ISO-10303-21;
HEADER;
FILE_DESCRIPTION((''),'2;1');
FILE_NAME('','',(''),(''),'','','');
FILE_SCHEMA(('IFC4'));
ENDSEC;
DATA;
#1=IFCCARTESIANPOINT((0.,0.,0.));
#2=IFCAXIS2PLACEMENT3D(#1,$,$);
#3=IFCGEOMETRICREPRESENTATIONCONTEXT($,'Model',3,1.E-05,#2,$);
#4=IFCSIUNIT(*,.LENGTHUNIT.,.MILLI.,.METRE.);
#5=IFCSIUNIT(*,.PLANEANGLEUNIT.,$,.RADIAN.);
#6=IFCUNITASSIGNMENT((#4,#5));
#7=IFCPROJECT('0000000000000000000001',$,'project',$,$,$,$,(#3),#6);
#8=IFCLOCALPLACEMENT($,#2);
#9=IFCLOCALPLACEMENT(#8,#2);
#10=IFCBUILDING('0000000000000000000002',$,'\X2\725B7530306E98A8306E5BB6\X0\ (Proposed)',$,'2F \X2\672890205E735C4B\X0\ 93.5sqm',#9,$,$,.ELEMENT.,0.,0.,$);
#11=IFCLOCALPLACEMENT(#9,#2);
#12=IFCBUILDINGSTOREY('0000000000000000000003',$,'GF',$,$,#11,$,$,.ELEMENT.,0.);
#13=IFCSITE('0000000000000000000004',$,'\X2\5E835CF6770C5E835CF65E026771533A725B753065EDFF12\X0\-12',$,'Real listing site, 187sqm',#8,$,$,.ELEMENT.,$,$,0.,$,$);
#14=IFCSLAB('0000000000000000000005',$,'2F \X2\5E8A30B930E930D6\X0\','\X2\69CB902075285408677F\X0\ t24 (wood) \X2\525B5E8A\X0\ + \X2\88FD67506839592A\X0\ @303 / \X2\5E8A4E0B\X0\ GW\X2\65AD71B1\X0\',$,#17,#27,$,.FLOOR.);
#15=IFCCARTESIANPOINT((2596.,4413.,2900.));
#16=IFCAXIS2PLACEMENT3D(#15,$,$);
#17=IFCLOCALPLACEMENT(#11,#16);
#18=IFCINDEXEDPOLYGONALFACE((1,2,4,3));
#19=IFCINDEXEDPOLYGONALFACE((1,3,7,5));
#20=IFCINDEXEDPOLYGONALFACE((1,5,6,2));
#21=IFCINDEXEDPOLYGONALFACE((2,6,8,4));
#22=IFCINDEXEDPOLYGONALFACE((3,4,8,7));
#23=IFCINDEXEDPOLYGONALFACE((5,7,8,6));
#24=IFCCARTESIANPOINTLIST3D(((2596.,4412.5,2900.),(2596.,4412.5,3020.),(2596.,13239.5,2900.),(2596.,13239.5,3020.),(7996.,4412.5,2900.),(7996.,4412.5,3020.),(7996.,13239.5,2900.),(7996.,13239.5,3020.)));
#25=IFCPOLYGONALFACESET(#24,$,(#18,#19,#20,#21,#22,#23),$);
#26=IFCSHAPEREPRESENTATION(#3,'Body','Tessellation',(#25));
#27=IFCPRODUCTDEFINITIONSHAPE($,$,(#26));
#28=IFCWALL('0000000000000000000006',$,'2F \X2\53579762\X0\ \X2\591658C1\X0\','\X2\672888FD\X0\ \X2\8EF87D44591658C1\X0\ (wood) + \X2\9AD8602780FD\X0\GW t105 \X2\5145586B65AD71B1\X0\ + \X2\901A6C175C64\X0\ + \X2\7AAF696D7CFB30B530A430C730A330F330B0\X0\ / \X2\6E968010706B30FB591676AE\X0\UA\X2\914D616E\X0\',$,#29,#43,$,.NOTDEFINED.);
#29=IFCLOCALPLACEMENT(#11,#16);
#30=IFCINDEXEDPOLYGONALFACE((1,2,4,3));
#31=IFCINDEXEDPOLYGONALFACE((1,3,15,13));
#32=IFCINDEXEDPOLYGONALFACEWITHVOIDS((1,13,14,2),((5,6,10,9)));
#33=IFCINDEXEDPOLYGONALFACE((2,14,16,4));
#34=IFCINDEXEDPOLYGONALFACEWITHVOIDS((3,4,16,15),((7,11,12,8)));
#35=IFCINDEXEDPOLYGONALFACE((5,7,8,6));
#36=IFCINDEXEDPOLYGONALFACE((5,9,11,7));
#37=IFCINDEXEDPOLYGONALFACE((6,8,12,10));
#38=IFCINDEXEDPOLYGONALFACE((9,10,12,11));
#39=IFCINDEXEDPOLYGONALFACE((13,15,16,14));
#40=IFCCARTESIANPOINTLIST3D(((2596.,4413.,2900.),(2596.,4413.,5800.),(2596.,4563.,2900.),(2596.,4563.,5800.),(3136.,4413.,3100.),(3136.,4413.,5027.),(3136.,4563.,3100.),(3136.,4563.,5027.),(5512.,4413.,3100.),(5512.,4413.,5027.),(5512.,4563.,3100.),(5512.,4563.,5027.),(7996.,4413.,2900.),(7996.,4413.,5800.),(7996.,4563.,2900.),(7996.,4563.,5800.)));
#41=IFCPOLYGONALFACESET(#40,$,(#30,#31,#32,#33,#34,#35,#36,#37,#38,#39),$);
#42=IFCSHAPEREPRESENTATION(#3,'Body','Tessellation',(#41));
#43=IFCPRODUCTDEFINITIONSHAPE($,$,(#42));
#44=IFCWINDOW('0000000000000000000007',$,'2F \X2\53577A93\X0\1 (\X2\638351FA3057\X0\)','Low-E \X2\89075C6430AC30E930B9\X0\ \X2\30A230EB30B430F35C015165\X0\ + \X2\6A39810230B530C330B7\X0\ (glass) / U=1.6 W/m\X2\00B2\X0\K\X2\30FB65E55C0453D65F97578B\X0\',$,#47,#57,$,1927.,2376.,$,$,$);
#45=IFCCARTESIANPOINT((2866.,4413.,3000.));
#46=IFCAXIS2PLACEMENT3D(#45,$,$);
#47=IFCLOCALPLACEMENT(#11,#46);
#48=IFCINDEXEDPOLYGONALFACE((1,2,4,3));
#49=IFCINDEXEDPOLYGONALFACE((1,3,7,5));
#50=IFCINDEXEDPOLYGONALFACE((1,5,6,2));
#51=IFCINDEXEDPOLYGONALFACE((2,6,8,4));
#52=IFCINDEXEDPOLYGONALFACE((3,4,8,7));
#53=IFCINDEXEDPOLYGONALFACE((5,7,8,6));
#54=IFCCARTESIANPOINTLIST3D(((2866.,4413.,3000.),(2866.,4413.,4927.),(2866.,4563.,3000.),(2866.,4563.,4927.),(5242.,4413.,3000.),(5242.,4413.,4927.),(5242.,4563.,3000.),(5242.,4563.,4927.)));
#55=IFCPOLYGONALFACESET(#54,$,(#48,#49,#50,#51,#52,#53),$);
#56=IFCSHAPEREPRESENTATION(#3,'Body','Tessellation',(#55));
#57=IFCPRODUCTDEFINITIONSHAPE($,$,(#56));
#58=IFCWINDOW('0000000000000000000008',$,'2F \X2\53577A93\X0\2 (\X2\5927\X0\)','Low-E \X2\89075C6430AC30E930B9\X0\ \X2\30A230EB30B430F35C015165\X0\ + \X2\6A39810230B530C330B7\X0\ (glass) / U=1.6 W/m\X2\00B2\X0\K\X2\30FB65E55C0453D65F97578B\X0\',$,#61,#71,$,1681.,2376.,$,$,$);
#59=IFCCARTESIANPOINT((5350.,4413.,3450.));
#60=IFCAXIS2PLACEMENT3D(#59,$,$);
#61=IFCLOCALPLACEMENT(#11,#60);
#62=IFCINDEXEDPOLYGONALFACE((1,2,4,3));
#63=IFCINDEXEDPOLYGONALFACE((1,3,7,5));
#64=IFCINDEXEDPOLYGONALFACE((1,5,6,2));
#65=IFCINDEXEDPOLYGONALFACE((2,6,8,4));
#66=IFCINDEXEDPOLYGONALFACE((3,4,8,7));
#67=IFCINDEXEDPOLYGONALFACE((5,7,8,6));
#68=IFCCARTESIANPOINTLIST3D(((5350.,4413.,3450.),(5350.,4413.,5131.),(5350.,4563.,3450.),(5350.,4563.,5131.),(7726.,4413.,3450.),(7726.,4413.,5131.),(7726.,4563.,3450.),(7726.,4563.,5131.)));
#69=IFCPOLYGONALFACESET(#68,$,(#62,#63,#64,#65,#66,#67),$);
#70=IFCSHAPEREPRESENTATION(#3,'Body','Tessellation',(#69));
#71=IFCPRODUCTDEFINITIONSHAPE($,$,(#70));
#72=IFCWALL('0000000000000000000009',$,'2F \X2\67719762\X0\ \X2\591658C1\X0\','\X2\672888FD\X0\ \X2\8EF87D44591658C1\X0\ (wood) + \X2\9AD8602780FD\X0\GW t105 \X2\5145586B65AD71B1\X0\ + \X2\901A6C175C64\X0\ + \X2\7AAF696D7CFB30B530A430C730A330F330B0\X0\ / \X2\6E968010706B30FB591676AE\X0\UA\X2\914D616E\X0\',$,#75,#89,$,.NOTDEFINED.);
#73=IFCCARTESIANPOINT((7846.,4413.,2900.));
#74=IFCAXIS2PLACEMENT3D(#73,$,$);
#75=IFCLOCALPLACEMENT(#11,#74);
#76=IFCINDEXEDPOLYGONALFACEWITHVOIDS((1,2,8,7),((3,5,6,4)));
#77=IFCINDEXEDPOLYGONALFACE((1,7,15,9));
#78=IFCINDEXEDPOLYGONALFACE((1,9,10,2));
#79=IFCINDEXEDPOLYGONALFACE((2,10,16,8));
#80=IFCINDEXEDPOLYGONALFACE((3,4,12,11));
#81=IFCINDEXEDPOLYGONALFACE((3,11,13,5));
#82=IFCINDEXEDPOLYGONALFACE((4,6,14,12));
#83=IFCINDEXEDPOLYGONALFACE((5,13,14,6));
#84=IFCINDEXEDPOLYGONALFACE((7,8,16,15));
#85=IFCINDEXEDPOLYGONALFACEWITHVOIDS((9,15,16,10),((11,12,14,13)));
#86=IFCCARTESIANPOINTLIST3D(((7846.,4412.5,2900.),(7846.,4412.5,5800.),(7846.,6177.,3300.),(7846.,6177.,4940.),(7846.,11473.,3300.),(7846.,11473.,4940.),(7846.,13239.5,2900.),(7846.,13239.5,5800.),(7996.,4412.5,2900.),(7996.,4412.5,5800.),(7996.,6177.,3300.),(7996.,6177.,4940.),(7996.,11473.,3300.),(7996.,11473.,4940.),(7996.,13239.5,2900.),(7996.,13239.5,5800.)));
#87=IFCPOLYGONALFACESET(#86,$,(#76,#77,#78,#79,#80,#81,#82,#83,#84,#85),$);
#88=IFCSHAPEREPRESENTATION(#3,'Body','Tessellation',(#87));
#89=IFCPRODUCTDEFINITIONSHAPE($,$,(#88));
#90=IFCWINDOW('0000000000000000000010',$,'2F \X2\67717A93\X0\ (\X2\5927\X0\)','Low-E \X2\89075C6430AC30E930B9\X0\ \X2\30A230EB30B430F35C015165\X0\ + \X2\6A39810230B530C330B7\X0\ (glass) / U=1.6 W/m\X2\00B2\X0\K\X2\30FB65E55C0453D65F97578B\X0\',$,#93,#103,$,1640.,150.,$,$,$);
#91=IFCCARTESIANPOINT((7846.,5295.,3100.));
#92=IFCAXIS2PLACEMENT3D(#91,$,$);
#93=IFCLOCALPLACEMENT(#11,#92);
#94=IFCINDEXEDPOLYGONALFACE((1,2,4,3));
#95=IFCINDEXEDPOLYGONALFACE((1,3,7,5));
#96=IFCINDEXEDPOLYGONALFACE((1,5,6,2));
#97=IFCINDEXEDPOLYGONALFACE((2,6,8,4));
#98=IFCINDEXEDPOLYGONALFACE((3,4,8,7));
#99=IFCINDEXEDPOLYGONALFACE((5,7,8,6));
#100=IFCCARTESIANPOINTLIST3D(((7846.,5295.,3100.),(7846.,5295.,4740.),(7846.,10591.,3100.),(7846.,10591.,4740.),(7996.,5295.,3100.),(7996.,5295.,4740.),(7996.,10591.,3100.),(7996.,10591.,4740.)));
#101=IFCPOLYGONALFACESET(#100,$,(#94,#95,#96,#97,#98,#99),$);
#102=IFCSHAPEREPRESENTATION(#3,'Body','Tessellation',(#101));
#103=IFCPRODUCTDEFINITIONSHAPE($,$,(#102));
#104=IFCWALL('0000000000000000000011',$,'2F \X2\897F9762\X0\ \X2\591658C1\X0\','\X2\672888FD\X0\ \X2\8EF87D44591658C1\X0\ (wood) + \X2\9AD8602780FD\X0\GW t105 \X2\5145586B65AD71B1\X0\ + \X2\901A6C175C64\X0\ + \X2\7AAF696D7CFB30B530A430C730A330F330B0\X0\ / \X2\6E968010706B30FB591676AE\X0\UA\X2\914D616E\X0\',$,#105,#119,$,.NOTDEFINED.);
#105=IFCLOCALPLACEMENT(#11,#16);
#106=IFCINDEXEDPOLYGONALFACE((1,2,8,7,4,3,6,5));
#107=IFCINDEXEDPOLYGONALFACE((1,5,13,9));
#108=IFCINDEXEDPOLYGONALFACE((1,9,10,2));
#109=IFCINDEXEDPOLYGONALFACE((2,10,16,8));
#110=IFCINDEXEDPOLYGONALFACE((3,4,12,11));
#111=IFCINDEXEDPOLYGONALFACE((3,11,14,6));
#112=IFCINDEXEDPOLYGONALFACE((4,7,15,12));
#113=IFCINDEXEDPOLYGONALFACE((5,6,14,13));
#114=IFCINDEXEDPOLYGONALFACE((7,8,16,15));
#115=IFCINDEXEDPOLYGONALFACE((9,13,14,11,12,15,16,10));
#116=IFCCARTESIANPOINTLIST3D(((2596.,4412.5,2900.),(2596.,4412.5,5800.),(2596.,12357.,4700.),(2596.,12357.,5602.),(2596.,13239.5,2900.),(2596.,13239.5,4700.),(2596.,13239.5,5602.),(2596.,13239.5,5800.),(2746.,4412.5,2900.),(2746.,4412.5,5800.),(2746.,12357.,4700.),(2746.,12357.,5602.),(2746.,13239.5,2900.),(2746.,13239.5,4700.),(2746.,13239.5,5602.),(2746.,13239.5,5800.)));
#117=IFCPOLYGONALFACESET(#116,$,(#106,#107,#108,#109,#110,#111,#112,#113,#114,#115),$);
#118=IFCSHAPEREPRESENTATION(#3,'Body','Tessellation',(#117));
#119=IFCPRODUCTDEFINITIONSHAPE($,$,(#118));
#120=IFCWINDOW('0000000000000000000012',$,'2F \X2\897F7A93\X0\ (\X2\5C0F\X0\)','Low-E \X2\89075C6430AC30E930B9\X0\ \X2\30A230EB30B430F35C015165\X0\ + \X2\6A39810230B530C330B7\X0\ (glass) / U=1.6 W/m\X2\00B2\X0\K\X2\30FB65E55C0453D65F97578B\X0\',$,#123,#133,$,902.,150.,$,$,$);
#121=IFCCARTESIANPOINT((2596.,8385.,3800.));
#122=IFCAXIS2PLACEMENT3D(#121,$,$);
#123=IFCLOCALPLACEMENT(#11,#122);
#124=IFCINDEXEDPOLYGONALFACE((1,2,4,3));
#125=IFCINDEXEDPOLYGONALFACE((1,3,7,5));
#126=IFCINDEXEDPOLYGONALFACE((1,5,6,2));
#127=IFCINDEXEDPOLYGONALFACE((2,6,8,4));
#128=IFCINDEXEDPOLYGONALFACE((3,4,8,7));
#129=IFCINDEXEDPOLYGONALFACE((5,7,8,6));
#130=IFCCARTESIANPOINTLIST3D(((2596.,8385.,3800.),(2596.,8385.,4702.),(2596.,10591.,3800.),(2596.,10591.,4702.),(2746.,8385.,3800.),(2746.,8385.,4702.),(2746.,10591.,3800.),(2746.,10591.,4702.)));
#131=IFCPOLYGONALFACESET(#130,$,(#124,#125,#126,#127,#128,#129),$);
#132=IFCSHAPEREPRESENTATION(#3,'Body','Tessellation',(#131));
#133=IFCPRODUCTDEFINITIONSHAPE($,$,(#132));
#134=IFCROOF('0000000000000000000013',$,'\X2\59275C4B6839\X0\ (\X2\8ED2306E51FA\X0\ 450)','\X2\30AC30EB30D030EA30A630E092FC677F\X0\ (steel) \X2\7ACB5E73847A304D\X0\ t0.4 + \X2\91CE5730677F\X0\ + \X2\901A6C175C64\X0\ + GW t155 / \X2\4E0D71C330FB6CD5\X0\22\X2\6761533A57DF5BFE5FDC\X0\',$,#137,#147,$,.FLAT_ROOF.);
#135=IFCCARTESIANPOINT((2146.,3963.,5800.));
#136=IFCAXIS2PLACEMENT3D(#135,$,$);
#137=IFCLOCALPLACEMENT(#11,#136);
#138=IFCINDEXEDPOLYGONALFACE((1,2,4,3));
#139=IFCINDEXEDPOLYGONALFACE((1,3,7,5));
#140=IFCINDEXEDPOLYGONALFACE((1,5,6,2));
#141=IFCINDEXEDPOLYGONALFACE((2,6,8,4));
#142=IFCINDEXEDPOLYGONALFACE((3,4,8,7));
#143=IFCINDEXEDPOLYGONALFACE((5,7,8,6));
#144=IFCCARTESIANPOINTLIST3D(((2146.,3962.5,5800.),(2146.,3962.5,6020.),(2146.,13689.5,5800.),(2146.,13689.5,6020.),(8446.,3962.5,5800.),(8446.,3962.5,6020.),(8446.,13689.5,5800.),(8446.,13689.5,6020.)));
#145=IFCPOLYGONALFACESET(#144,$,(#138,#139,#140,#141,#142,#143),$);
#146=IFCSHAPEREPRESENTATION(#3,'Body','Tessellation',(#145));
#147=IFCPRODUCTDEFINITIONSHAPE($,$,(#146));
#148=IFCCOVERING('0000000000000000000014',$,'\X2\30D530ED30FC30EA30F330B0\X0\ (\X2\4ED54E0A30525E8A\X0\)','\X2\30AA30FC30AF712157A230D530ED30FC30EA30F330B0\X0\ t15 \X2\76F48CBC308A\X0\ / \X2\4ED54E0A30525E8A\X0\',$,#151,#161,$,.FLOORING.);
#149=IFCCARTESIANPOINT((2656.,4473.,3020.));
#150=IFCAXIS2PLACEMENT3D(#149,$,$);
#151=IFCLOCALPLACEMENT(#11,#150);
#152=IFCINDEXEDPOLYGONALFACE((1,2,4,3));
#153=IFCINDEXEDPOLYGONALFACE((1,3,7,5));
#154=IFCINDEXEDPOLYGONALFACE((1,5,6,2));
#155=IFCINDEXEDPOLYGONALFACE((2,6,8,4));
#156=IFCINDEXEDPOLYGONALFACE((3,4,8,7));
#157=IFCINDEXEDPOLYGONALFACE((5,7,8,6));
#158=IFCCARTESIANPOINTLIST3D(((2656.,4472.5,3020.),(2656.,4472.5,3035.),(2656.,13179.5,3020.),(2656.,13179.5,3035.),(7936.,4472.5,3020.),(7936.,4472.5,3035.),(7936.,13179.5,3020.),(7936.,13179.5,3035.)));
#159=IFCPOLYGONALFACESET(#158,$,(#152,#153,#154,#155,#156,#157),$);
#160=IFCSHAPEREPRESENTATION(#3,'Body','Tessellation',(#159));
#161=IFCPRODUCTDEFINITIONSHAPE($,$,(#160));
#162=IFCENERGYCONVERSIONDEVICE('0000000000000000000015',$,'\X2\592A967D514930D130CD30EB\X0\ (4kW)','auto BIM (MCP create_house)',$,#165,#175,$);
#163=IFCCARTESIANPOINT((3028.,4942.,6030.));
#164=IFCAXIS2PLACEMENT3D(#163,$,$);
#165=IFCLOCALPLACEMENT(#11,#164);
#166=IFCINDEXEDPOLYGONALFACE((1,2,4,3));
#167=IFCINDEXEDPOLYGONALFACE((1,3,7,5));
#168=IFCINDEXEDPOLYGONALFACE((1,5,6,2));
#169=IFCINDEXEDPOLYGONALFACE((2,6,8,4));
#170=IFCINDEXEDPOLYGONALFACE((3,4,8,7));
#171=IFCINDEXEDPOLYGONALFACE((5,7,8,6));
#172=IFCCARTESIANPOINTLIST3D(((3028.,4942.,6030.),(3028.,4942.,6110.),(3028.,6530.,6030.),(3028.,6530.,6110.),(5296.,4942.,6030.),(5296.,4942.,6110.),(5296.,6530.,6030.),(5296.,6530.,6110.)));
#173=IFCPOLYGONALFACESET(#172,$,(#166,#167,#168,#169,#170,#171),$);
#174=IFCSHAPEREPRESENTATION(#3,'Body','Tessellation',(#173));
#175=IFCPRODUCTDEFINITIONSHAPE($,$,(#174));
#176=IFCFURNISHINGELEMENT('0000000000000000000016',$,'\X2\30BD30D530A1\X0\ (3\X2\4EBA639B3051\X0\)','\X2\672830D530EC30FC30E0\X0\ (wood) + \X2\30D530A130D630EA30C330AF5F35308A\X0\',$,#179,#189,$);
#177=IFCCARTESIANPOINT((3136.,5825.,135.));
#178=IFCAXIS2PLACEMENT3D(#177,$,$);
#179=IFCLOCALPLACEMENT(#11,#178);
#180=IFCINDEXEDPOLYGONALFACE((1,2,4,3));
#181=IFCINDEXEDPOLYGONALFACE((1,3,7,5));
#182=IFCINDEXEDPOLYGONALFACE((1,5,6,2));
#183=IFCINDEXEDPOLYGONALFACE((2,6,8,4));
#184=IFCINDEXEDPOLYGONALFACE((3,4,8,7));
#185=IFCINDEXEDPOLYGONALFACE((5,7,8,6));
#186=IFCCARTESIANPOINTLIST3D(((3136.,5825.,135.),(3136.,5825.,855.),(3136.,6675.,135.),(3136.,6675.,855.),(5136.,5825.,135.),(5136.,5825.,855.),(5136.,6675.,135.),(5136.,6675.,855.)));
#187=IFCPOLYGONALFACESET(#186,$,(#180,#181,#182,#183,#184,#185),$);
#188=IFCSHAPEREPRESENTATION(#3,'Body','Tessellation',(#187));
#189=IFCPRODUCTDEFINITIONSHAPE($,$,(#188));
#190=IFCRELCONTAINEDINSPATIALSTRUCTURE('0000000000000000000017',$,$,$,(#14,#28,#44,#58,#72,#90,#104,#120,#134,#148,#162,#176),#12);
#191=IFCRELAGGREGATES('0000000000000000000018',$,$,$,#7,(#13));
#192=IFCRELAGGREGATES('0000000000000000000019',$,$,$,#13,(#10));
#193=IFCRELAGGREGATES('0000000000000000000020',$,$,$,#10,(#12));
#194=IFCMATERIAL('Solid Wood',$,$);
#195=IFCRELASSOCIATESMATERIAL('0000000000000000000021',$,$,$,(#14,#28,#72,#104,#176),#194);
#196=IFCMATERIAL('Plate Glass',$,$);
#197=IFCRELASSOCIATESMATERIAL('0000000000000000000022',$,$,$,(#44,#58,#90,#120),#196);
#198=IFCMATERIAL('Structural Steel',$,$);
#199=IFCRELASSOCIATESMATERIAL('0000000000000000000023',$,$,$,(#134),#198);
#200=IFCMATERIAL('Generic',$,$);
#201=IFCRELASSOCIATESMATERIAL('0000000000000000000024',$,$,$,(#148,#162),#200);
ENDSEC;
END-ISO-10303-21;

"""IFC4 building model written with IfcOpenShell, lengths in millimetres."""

from ifc_helpers import new_model, si_unit, frame, frame_2d, origin, place, context, project, spatial, rectangle, extrude, material, element, fill, save


model = new_model("IFC4")

# Units and contexts
model_context = context("Model", 3, precision=1e-05, world=origin())
ifc_project = project(units=[si_unit("LENGTHUNIT", "METRE", prefix="MILLI"), si_unit("PLANEANGLEUNIT", "RADIAN")], contexts=[model_context])

# Site, building, storey
site_placement = place(None, origin())
site = spatial("IfcSite", under=ifc_project, at=site_placement, Name="広島県広島市東区牛田旭２-12", ObjectType="Real listing site, 187sqm", CompositionType="ELEMENT", RefElevation=0.0)
building_placement = place(site_placement, origin())
building = spatial("IfcBuilding", under=site, at=building_placement, Name="牛田の風の家 (Proposed)", ObjectType="2F 木造平屋 93.5sqm", CompositionType="ELEMENT", ElevationOfRefHeight=0.0, ElevationOfTerrain=0.0)
storey_placement = place(building_placement, origin())
storey = spatial("IfcBuildingStorey", under=building, at=storey_placement, Name="GF", CompositionType="ELEMENT", Elevation=0.0)

# Slab
ifc_material_1 = material(Name="Solid Wood")
slab_placement = place(storey_placement, frame((2596.0, 4413.0, 2900.0)))
element("IfcSlab", 1, at=slab_placement, inside=storey, material=ifc_material_1, Name="2F 床スラブ", Description="構造用合板 t24 (wood) 剛床 + 製材根太 @303 / 床下 GW断熱", PredefinedType="FLOOR", context=model_context, shape_type="SweptSolid", body=[
    extrude(rectangle(XDim=5400.0, YDim=8827.0, at=frame_2d((2700.0, 4413.0))), frame((2596.0, 4413.0, 2900.0)), (0.0, 0.0, 1.0), 120.0),
])

# Wall, openings, windows
wall_1_placement = place(storey_placement, frame((2596.0, 4413.0, 2900.0)))
wall_1 = element("IfcWall", 2, at=wall_1_placement, inside=storey, material=ifc_material_1, Name="2F 南面 外壁", Description="木製 軸組外壁 (wood) + 高性能GW t105 充填断熱 + 通気層 + 窯業系サイディング / 準耐火・外皮UA配慮", PredefinedType="NOTDEFINED", context=model_context, shape_type="SweptSolid", body=[
    extrude(rectangle(XDim=5400.0, YDim=150.0, at=frame_2d((2700.0, 75.0))), frame((2596.0, 4413.0, 2900.0)), (0.0, 0.0, 1.0), 2900.0),
])
opening_1_placement = place(storey_placement, frame((2866.0, 4413.0, 3000.0)))
opening_1 = element("IfcOpeningElement", 3, at=opening_1_placement, cuts=wall_1, PredefinedType="NOTDEFINED", context=model_context, shape_type="SweptSolid", body=[
    extrude(rectangle(XDim=2376.0, YDim=150.0, at=frame_2d((1188.0, 75.0))), frame((2866.0, 4413.0, 3000.0)), (0.0, 0.0, 1.0), 1927.0),
])
opening_2_placement = place(storey_placement, frame((5350.0, 4413.0, 3450.0)))
opening_2 = element("IfcOpeningElement", 4, at=opening_2_placement, cuts=wall_1, PredefinedType="NOTDEFINED", context=model_context, shape_type="SweptSolid", body=[
    extrude(rectangle(XDim=2376.0, YDim=150.0, at=frame_2d((1188.0, 75.0))), frame((5350.0, 4413.0, 3450.0)), (0.0, 0.0, 1.0), 1681.0),
])
ifc_material_2 = material(Name="Plate Glass")
window_1_placement = place(storey_placement, frame((2866.0, 4413.0, 3000.0)))
window_1 = element("IfcWindow", 5, at=window_1_placement, inside=storey, material=ifc_material_2, Name="2F 南窓1 (掃出し)", Description="Low-E 複層ガラス アルゴン封入 + 樹脂サッシ (glass) / U=1.6 W/m²K・日射取得型", OverallHeight=1927.0, OverallWidth=2376.0, context=model_context, shape_type="SweptSolid", body=[
    extrude(rectangle(XDim=2376.0, YDim=150.0, at=frame_2d((1188.0, 75.0))), frame((2866.0, 4413.0, 3000.0)), (0.0, 0.0, 1.0), 1927.0),
])
fill(opening_1, window_1)
window_2_placement = place(storey_placement, frame((5350.0, 4413.0, 3450.0)))
window_2 = element("IfcWindow", 6, at=window_2_placement, inside=storey, material=ifc_material_2, Name="2F 南窓2 (大)", Description="Low-E 複層ガラス アルゴン封入 + 樹脂サッシ (glass) / U=1.6 W/m²K・日射取得型", OverallHeight=1681.0, OverallWidth=2376.0, context=model_context, shape_type="SweptSolid", body=[
    extrude(rectangle(XDim=2376.0, YDim=150.0, at=frame_2d((1188.0, 75.0))), frame((5350.0, 4413.0, 3450.0)), (0.0, 0.0, 1.0), 1681.0),
])
fill(opening_2, window_2)

# Walls, openings, windows
wall_2_placement = place(storey_placement, frame((7846.0, 4413.0, 2900.0)))
wall_2 = element("IfcWall", 7, at=wall_2_placement, inside=storey, material=ifc_material_1, Name="2F 東面 外壁", Description="木製 軸組外壁 (wood) + 高性能GW t105 充填断熱 + 通気層 + 窯業系サイディング / 準耐火・外皮UA配慮", PredefinedType="NOTDEFINED", context=model_context, shape_type="SweptSolid", body=[
    extrude(rectangle(XDim=150.0, YDim=8827.0, at=frame_2d((75.0, 4413.0))), frame((7846.0, 4413.0, 2900.0)), (0.0, 0.0, 1.0), 2900.0),
])
opening_3_placement = place(storey_placement, frame((7846.0, 5295.0, 3100.0)))
opening_3 = element("IfcOpeningElement", 8, at=opening_3_placement, cuts=wall_2, PredefinedType="NOTDEFINED", context=model_context, shape_type="SweptSolid", body=[
    extrude(rectangle(XDim=150.0, YDim=5296.0, at=frame_2d((75.0, 2648.0))), frame((7846.0, 5295.0, 3100.0)), (0.0, 0.0, 1.0), 1640.0),
])
window_3_placement = place(storey_placement, frame((7846.0, 5295.0, 3100.0)))
window_3 = element("IfcWindow", 9, at=window_3_placement, inside=storey, material=ifc_material_2, Name="2F 東窓 (大)", Description="Low-E 複層ガラス アルゴン封入 + 樹脂サッシ (glass) / U=1.6 W/m²K・日射取得型", OverallHeight=1640.0, OverallWidth=150.0, context=model_context, shape_type="SweptSolid", body=[
    extrude(rectangle(XDim=150.0, YDim=5296.0, at=frame_2d((75.0, 2648.0))), frame((7846.0, 5295.0, 3100.0)), (0.0, 0.0, 1.0), 1640.0),
])
fill(opening_3, window_3)
wall_3_placement = place(storey_placement, frame((2596.0, 4413.0, 2900.0)))
wall_3 = element("IfcWall", 10, at=wall_3_placement, inside=storey, material=ifc_material_1, Name="2F 西面 外壁", Description="木製 軸組外壁 (wood) + 高性能GW t105 充填断熱 + 通気層 + 窯業系サイディング / 準耐火・外皮UA配慮", PredefinedType="NOTDEFINED", context=model_context, shape_type="SweptSolid", body=[
    extrude(rectangle(XDim=150.0, YDim=8827.0, at=frame_2d((75.0, 4413.0))), frame((2596.0, 4413.0, 2900.0)), (0.0, 0.0, 1.0), 2900.0),
])
opening_4_placement = place(storey_placement, frame((2596.0, 8385.0, 3800.0)))
opening_4 = element("IfcOpeningElement", 11, at=opening_4_placement, cuts=wall_3, PredefinedType="NOTDEFINED", context=model_context, shape_type="SweptSolid", body=[
    extrude(rectangle(XDim=150.0, YDim=2206.0, at=frame_2d((75.0, 1103.0))), frame((2596.0, 8385.0, 3800.0)), (0.0, 0.0, 1.0), 902.0),
])
window_4_placement = place(storey_placement, frame((2596.0, 8385.0, 3800.0)))
window_4 = element("IfcWindow", 12, at=window_4_placement, inside=storey, material=ifc_material_2, Name="2F 西窓 (小)", Description="Low-E 複層ガラス アルゴン封入 + 樹脂サッシ (glass) / U=1.6 W/m²K・日射取得型", OverallHeight=902.0, OverallWidth=150.0, context=model_context, shape_type="SweptSolid", body=[
    extrude(rectangle(XDim=150.0, YDim=2206.0, at=frame_2d((75.0, 1103.0))), frame((2596.0, 8385.0, 3800.0)), (0.0, 0.0, 1.0), 902.0),
])
fill(opening_4, window_4)

# Roof
ifc_material_3 = material(Name="Structural Steel")
roof_placement = place(storey_placement, frame((2146.0, 3963.0, 5800.0)))
element("IfcRoof", 13, at=roof_placement, inside=storey, material=ifc_material_3, Name="大屋根 (軒の出 450)", Description="ガルバリウム鋼板 (steel) 立平葺き t0.4 + 野地板 + 通気層 + GW t155 / 不燃・法22条区域対応", PredefinedType="FLAT_ROOF", context=model_context, shape_type="SweptSolid", body=[
    extrude(rectangle(XDim=6300.0, YDim=9727.0, at=frame_2d((3150.0, 4863.0))), frame((2146.0, 3963.0, 5800.0)), (0.0, 0.0, 1.0), 220.0),
])

# Covering
ifc_material_4 = material(Name="Generic")
covering_placement = place(storey_placement, frame((2656.0, 4473.0, 3020.0)))
element("IfcCovering", 14, at=covering_placement, inside=storey, material=ifc_material_4, Name="フローリング (仕上げ床)", Description="オーク無垢フローリング t15 直貼り / 仕上げ床", PredefinedType="FLOORING", context=model_context, shape_type="SweptSolid", body=[
    extrude(rectangle(XDim=5280.0, YDim=8707.0, at=frame_2d((2640.0, 4353.0))), frame((2656.0, 4473.0, 3020.0)), (0.0, 0.0, 1.0), 15.0),
])

# Energy conversion device
energy_conversion_device_placement = place(storey_placement, frame((3028.0, 4942.0, 6030.0)))
element("IfcEnergyConversionDevice", 15, at=energy_conversion_device_placement, inside=storey, material=ifc_material_4, Name="太陽光パネル (4kW)", Description="auto BIM (MCP create_house)", context=model_context, shape_type="SweptSolid", body=[
    extrude(rectangle(XDim=2268.0, YDim=1588.0, at=frame_2d((1134.0, 794.0))), frame((3028.0, 4942.0, 6030.0)), (0.0, 0.0, 1.0), 80.0),
])

# Furnishing element
furnishing_1_placement = place(storey_placement, frame((3136.0, 5825.0, 135.0)))
element("IfcFurnishingElement", 16, at=furnishing_1_placement, inside=storey, material=ifc_material_1, Name="ソファ (3人掛け)", Description="木フレーム (wood) + ファブリック張り", context=model_context, shape_type="SweptSolid", body=[
    extrude(rectangle(XDim=2000.0, YDim=850.0, at=frame_2d((1000.0, 425.0))), frame((3136.0, 5825.0, 135.0)), (0.0, 0.0, 1.0), 720.0),
])

save(model, "model.ifc")
